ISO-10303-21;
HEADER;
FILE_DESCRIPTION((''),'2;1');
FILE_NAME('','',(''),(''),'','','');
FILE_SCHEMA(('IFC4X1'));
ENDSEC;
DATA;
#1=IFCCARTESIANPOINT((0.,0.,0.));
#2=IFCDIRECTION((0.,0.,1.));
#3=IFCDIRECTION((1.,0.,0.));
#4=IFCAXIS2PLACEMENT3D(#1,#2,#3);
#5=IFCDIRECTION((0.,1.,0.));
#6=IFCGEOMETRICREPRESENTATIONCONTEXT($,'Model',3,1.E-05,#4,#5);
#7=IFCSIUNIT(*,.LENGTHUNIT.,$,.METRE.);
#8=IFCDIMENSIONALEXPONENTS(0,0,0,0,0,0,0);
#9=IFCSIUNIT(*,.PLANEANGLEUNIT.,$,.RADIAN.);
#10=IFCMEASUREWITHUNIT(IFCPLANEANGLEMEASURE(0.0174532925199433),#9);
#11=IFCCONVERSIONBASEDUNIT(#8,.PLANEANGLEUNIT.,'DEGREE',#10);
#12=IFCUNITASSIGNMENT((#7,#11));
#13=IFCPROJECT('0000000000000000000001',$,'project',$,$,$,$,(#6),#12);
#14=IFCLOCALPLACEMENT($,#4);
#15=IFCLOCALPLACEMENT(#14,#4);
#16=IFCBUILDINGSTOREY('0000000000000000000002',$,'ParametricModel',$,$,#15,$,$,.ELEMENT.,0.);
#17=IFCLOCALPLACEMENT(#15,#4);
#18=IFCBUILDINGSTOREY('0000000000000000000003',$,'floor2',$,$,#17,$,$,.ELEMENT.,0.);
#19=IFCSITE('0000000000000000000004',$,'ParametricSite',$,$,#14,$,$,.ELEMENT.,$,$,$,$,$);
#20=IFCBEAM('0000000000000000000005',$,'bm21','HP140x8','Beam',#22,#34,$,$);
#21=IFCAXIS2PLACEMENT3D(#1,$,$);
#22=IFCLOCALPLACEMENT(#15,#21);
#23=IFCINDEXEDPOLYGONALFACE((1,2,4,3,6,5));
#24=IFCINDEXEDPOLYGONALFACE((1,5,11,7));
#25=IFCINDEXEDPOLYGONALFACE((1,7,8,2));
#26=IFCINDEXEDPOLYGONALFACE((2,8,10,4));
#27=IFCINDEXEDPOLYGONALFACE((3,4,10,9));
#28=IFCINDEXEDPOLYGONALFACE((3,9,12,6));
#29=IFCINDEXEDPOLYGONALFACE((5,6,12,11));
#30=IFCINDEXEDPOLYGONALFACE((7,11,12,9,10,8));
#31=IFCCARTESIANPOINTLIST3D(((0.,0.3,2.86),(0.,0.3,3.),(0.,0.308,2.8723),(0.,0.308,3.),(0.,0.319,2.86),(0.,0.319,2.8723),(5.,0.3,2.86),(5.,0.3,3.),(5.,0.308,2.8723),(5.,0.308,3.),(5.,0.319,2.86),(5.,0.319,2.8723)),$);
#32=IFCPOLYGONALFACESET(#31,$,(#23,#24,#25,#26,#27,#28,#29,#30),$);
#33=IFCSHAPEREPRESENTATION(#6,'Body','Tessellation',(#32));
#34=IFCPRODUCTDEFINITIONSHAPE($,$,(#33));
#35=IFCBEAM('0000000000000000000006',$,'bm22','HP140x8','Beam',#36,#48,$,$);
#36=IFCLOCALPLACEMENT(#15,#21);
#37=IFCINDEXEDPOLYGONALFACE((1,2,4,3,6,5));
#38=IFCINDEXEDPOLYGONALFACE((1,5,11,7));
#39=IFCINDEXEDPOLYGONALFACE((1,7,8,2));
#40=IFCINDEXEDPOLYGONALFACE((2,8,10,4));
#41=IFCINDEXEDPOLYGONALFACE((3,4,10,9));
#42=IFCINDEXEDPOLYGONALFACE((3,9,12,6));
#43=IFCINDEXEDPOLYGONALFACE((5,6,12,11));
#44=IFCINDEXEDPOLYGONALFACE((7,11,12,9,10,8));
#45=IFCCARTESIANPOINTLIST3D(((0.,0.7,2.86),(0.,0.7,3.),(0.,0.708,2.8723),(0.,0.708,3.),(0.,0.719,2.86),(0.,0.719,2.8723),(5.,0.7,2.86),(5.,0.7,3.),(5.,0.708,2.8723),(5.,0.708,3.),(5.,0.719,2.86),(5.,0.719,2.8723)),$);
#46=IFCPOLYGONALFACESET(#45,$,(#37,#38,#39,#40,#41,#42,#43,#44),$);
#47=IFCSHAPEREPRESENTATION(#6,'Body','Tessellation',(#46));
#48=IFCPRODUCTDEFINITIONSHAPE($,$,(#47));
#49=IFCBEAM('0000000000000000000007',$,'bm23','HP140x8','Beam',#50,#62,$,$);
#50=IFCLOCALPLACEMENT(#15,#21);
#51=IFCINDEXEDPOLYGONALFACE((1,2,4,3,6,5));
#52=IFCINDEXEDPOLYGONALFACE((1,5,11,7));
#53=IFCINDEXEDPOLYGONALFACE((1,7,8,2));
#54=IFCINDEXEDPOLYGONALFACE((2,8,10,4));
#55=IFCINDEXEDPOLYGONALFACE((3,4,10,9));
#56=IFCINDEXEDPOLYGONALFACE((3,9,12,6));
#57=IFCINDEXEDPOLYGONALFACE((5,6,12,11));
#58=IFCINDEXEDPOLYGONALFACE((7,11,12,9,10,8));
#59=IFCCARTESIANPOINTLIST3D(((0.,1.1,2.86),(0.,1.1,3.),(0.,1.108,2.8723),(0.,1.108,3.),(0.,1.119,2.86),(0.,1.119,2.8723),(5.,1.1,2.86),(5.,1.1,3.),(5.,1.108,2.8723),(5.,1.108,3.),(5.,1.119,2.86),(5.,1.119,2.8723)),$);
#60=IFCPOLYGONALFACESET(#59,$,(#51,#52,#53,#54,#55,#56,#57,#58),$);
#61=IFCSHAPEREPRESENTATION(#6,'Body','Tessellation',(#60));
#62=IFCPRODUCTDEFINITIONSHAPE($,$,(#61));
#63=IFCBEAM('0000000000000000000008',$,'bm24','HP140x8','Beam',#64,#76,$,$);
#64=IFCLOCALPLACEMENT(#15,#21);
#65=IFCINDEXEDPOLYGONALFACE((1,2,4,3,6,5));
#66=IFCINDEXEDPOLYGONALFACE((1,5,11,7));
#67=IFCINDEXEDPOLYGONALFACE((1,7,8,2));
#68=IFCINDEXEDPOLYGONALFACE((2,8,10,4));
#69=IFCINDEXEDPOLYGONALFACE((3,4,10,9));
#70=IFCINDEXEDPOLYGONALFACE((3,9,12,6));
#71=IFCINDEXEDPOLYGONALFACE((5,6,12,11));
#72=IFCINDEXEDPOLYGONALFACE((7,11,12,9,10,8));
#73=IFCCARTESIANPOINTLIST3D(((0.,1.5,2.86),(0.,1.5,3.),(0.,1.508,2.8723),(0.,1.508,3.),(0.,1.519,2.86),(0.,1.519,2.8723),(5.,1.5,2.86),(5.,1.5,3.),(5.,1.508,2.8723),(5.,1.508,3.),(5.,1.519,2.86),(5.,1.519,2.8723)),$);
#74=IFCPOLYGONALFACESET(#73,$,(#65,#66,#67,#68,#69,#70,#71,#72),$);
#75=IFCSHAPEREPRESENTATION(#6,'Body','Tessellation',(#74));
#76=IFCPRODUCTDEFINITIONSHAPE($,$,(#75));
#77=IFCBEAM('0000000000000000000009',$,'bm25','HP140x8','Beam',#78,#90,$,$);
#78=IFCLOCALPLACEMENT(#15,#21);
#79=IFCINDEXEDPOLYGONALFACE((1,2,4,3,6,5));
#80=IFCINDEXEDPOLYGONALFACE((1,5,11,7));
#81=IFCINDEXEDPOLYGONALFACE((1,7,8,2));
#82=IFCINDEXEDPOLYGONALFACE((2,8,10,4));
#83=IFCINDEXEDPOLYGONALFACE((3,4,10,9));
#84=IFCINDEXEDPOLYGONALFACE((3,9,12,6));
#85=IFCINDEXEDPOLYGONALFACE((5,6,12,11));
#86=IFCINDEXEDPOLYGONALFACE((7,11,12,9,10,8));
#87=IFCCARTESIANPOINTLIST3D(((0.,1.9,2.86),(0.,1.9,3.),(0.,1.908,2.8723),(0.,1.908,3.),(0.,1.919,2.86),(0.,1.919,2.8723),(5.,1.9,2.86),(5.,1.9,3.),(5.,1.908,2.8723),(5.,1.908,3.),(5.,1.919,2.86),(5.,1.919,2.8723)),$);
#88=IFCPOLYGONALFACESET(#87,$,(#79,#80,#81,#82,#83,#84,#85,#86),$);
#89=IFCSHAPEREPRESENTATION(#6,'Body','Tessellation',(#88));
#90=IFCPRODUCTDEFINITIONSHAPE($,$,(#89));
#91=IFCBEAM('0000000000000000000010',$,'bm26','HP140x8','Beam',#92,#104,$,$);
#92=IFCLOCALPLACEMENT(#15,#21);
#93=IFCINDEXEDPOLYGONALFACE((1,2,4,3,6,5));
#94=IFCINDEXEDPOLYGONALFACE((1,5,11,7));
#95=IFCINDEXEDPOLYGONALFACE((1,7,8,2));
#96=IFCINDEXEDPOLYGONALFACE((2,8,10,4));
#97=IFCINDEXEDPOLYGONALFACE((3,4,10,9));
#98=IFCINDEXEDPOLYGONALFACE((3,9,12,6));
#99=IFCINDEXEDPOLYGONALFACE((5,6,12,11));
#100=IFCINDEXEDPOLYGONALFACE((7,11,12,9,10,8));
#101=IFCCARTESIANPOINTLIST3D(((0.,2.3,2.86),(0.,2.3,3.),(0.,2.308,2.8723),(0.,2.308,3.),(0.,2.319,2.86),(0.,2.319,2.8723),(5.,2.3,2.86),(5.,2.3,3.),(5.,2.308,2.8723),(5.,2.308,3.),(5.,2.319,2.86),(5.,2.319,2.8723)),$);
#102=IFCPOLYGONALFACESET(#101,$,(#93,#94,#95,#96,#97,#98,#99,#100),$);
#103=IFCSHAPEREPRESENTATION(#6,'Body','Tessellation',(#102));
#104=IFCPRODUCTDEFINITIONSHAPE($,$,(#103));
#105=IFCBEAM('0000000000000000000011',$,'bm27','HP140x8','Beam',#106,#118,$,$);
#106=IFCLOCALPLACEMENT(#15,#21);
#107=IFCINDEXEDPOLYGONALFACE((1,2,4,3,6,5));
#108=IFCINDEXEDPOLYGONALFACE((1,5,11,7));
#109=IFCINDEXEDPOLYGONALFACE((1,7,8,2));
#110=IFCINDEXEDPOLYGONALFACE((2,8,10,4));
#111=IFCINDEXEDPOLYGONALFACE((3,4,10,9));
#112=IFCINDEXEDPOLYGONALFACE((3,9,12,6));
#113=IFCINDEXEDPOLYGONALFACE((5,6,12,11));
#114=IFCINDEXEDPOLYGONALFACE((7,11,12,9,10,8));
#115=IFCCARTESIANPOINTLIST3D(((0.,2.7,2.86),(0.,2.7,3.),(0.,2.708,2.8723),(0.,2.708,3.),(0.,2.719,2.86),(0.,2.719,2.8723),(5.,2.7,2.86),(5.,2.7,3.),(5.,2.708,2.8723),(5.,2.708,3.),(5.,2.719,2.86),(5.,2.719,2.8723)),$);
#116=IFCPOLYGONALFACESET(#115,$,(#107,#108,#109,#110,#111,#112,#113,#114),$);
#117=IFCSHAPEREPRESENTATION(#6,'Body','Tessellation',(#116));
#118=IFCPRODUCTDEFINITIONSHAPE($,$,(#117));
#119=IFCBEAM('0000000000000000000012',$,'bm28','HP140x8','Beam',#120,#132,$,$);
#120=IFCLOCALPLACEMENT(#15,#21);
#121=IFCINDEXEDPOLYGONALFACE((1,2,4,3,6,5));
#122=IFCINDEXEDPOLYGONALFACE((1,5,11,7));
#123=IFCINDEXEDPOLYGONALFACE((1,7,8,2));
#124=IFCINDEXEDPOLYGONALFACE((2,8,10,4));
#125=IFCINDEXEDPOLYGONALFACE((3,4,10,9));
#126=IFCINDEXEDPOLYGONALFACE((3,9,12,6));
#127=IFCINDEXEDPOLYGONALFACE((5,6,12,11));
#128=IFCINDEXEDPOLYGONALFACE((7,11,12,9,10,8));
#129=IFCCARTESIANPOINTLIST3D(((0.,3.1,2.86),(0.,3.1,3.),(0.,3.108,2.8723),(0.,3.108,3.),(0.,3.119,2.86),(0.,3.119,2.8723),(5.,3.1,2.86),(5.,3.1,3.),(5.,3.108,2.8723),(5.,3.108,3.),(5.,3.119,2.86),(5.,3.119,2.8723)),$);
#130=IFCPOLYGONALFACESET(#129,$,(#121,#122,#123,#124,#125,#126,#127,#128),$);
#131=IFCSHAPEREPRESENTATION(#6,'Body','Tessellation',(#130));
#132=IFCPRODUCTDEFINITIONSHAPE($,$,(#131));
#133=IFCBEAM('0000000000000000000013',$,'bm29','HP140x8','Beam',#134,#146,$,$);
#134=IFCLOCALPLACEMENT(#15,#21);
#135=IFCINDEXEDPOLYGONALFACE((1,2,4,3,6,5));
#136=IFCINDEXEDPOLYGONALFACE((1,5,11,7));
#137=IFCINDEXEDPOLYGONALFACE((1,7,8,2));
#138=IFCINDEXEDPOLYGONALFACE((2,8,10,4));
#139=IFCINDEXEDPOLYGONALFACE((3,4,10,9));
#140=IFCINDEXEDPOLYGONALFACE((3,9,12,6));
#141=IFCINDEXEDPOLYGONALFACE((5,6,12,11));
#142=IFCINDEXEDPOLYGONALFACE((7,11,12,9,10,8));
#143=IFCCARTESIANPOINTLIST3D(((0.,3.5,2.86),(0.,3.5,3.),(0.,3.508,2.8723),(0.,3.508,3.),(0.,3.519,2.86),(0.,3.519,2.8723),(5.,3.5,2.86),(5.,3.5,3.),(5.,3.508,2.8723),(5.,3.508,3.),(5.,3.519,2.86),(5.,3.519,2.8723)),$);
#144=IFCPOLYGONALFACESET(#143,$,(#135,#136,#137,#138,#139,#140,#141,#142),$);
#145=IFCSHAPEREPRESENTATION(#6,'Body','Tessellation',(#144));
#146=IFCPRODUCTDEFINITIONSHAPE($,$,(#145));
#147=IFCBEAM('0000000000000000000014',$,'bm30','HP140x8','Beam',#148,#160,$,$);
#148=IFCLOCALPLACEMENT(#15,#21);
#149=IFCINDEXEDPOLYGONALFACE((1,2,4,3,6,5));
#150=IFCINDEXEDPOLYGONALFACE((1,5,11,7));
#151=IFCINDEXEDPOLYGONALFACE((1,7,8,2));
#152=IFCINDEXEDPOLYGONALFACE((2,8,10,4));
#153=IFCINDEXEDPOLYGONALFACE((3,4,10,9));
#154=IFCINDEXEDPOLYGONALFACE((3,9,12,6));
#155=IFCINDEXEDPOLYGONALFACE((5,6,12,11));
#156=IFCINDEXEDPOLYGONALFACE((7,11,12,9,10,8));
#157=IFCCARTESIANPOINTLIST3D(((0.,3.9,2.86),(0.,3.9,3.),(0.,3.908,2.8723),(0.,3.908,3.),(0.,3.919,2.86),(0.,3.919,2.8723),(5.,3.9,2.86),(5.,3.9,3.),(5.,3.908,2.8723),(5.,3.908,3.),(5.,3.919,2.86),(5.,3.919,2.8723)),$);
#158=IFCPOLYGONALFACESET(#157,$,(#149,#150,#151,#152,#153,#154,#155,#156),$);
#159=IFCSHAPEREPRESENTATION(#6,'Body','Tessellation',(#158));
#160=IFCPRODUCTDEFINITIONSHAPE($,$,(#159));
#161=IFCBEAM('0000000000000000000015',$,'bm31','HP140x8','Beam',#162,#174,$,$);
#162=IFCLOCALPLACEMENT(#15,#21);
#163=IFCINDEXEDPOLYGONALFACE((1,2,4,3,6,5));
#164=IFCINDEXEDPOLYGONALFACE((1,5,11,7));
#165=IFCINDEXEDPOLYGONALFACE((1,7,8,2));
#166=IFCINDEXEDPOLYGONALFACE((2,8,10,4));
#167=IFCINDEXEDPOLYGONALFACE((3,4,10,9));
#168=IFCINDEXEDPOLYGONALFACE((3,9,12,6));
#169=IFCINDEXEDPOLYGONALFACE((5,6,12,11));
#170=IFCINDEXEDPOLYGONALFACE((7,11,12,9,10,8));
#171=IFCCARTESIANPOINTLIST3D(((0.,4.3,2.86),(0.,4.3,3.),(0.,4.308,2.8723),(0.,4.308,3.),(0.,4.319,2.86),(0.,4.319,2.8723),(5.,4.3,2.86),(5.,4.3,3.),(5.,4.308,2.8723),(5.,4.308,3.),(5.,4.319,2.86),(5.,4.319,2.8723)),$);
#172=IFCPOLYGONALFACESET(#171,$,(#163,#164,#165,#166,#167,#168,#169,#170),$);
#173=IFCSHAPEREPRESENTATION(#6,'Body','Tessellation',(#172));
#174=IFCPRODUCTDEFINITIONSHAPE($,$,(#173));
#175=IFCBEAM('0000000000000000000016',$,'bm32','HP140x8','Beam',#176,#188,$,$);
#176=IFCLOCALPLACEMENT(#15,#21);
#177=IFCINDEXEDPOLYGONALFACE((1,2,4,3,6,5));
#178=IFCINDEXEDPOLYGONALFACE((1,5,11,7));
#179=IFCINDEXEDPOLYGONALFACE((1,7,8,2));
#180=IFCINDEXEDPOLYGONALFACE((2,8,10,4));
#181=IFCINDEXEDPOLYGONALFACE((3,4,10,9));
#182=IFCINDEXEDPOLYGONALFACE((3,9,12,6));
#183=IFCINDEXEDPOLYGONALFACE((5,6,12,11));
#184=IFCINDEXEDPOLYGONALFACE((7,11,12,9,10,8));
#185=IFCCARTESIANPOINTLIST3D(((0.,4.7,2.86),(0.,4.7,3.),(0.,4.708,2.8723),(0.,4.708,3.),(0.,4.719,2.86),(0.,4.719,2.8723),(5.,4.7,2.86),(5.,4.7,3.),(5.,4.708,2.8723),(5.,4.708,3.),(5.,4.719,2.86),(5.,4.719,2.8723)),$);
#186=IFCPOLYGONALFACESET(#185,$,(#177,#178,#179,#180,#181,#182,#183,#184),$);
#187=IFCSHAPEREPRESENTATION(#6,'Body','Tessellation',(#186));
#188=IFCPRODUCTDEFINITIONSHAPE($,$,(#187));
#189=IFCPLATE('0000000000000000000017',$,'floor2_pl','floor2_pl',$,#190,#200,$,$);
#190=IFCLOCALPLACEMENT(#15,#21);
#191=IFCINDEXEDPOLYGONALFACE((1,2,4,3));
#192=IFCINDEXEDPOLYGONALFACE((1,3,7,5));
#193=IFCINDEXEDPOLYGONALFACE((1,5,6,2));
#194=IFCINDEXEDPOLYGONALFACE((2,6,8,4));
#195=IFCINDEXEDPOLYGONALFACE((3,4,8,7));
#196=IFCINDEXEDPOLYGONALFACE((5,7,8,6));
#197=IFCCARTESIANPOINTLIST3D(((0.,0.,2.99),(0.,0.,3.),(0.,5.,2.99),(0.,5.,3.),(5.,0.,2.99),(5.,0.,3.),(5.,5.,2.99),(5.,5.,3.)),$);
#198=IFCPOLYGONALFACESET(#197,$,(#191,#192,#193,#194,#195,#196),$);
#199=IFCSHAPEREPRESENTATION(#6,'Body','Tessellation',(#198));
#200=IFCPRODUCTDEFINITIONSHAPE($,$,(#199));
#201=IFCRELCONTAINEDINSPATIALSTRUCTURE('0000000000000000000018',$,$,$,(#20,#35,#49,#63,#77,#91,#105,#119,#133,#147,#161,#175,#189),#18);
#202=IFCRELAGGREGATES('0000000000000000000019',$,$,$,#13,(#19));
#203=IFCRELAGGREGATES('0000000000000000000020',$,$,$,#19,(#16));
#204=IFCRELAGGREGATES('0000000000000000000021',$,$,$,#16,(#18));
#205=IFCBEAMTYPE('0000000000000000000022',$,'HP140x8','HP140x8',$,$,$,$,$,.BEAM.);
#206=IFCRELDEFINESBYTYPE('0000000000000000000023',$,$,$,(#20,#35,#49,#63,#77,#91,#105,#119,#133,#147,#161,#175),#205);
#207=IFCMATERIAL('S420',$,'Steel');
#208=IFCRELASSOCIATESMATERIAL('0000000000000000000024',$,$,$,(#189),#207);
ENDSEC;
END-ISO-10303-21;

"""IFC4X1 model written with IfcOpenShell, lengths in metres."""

from ifc_helpers import new_model, entity, si_unit, converted_unit, direction, frame, origin, origin_with_axes, place, context, project, spatial, polyline, line, indexed_curve, outline, extrude, material, type_object, element, save


model = new_model("IFC4X1")

# Units and contexts
model_context = context("Model", 3, precision=1e-05, world=origin_with_axes(), true_north=direction((0.0, 1.0, 0.0)))
ifc_project = project(units=[si_unit("LENGTHUNIT", "METRE"), converted_unit("PLANEANGLEUNIT", "DEGREE", entity("IfcPlaneAngleMeasure", 0.0174532925199433), si_unit("PLANEANGLEUNIT", "RADIAN"), dimensions=[0, 0, 0, 0, 0, 0, 0])], contexts=[model_context])

# Site, storeys
site_placement = place(None, origin_with_axes())
site = spatial("IfcSite", under=ifc_project, at=site_placement, Name="ParametricSite", CompositionType="ELEMENT")
storey_1_placement = place(site_placement, origin_with_axes())
storey_1 = spatial("IfcBuildingStorey", under=site, at=storey_1_placement, Name="ParametricModel", CompositionType="ELEMENT", Elevation=0.0)
storey_2_placement = place(storey_1_placement, origin_with_axes())
storey_2 = spatial("IfcBuildingStorey", under=storey_1, at=storey_2_placement, Name="floor2", CompositionType="ELEMENT", Elevation=0.0)

# Beams
beam_type = type_object("IfcBeamType", Name="HP140x8", Description="HP140x8", PredefinedType="BEAM")
plate_placement = place(storey_2_placement, origin_with_axes())
for number, where, z_axis, x_axis, name in (
    (1, (0.0, 0.3, 3.0), (1.0, 0.0, 0.0), (0.0, 1.0, 0.0), "bm21"),
    (2, (0.0, 0.7, 3.0), (1.0, 0.0, 0.0), (0.0, 1.0, 0.0), "bm22"),
    (3, (0.0, 1.1, 3.0), (1.0, 0.0, 0.0), (0.0, 1.0, 0.0), "bm23"),
    (4, (0.0, 1.5, 3.0), (1.0, 0.0, 0.0), (0.0, 1.0, 0.0), "bm24"),
    (5, (0.0, 1.9, 3.0), (1.0, 0.0, 0.0), (0.0, 1.0, 0.0), "bm25"),
    (6, (0.0, 2.3, 3.0), (1.0, 0.0, 0.0), (0.0, 1.0, 0.0), "bm26"),
    (7, (0.0, 2.7, 3.0), (1.0, 0.0, 0.0), (0.0, 1.0, 0.0), "bm27"),
    (8, (0.0, 3.1, 3.0), (1.0, 0.0, 0.0), (0.0, 1.0, 0.0), "bm28"),
    (9, (0.0, 3.5, 3.0), (1.0, 0.0, 0.0), (0.0, 1.0, 0.0), "bm29"),
    (10, (0.0, 3.9, 3.0), (1.0, 0.0, 0.0), (0.0, 1.0, 0.0), "bm30"),
    (11, (0.0, 4.3, 3.0), (1.0, 0.0, 0.0), (0.0, 1.0, 0.0), "bm31"),
    (12, (0.0, 4.7, 3.0), (1.0, 0.0, 0.0), (0.0, 1.0, 0.0), "bm32"),
):
    element("IfcBeam", number, at=place(plate_placement, frame(where, z_axis=z_axis, x_axis=x_axis)), inside=storey_2, type_object=beam_type, Name=name, Description="HP140x8", ObjectType="Beam", context=model_context, shape_type="SweptSolid", body=[
        extrude(outline(polyline([(0.0, 0.0), (0.008, 0.0), (0.008, -0.1277), (0.019, -0.1277), (0.019, -0.14), (0.0, -0.14)])), origin(), (0.0, 0.0, 1.0), 5.0),
    ])

# Plate
ifc_material = material(Name="S420", Category="Steel")
element("IfcPlate", 13, at=plate_placement, inside=storey_2, material=ifc_material, Name="floor2_pl", Description="floor2_pl", context=model_context, shape_type="SolidModel", body=[
    extrude(outline(indexed_curve([(0.0, 5.0, 3.0), (0.0, 0.0, 3.0), (5.0, 0.0, 3.0), (5.0, 5.0, 3.0)], segments=[line(1, 2), line(2, 3), line(3, 4), line(4, 1)])), origin_with_axes(), (0.0, 0.0, -1.0), 0.01),
])

save(model, "model.ifc")
